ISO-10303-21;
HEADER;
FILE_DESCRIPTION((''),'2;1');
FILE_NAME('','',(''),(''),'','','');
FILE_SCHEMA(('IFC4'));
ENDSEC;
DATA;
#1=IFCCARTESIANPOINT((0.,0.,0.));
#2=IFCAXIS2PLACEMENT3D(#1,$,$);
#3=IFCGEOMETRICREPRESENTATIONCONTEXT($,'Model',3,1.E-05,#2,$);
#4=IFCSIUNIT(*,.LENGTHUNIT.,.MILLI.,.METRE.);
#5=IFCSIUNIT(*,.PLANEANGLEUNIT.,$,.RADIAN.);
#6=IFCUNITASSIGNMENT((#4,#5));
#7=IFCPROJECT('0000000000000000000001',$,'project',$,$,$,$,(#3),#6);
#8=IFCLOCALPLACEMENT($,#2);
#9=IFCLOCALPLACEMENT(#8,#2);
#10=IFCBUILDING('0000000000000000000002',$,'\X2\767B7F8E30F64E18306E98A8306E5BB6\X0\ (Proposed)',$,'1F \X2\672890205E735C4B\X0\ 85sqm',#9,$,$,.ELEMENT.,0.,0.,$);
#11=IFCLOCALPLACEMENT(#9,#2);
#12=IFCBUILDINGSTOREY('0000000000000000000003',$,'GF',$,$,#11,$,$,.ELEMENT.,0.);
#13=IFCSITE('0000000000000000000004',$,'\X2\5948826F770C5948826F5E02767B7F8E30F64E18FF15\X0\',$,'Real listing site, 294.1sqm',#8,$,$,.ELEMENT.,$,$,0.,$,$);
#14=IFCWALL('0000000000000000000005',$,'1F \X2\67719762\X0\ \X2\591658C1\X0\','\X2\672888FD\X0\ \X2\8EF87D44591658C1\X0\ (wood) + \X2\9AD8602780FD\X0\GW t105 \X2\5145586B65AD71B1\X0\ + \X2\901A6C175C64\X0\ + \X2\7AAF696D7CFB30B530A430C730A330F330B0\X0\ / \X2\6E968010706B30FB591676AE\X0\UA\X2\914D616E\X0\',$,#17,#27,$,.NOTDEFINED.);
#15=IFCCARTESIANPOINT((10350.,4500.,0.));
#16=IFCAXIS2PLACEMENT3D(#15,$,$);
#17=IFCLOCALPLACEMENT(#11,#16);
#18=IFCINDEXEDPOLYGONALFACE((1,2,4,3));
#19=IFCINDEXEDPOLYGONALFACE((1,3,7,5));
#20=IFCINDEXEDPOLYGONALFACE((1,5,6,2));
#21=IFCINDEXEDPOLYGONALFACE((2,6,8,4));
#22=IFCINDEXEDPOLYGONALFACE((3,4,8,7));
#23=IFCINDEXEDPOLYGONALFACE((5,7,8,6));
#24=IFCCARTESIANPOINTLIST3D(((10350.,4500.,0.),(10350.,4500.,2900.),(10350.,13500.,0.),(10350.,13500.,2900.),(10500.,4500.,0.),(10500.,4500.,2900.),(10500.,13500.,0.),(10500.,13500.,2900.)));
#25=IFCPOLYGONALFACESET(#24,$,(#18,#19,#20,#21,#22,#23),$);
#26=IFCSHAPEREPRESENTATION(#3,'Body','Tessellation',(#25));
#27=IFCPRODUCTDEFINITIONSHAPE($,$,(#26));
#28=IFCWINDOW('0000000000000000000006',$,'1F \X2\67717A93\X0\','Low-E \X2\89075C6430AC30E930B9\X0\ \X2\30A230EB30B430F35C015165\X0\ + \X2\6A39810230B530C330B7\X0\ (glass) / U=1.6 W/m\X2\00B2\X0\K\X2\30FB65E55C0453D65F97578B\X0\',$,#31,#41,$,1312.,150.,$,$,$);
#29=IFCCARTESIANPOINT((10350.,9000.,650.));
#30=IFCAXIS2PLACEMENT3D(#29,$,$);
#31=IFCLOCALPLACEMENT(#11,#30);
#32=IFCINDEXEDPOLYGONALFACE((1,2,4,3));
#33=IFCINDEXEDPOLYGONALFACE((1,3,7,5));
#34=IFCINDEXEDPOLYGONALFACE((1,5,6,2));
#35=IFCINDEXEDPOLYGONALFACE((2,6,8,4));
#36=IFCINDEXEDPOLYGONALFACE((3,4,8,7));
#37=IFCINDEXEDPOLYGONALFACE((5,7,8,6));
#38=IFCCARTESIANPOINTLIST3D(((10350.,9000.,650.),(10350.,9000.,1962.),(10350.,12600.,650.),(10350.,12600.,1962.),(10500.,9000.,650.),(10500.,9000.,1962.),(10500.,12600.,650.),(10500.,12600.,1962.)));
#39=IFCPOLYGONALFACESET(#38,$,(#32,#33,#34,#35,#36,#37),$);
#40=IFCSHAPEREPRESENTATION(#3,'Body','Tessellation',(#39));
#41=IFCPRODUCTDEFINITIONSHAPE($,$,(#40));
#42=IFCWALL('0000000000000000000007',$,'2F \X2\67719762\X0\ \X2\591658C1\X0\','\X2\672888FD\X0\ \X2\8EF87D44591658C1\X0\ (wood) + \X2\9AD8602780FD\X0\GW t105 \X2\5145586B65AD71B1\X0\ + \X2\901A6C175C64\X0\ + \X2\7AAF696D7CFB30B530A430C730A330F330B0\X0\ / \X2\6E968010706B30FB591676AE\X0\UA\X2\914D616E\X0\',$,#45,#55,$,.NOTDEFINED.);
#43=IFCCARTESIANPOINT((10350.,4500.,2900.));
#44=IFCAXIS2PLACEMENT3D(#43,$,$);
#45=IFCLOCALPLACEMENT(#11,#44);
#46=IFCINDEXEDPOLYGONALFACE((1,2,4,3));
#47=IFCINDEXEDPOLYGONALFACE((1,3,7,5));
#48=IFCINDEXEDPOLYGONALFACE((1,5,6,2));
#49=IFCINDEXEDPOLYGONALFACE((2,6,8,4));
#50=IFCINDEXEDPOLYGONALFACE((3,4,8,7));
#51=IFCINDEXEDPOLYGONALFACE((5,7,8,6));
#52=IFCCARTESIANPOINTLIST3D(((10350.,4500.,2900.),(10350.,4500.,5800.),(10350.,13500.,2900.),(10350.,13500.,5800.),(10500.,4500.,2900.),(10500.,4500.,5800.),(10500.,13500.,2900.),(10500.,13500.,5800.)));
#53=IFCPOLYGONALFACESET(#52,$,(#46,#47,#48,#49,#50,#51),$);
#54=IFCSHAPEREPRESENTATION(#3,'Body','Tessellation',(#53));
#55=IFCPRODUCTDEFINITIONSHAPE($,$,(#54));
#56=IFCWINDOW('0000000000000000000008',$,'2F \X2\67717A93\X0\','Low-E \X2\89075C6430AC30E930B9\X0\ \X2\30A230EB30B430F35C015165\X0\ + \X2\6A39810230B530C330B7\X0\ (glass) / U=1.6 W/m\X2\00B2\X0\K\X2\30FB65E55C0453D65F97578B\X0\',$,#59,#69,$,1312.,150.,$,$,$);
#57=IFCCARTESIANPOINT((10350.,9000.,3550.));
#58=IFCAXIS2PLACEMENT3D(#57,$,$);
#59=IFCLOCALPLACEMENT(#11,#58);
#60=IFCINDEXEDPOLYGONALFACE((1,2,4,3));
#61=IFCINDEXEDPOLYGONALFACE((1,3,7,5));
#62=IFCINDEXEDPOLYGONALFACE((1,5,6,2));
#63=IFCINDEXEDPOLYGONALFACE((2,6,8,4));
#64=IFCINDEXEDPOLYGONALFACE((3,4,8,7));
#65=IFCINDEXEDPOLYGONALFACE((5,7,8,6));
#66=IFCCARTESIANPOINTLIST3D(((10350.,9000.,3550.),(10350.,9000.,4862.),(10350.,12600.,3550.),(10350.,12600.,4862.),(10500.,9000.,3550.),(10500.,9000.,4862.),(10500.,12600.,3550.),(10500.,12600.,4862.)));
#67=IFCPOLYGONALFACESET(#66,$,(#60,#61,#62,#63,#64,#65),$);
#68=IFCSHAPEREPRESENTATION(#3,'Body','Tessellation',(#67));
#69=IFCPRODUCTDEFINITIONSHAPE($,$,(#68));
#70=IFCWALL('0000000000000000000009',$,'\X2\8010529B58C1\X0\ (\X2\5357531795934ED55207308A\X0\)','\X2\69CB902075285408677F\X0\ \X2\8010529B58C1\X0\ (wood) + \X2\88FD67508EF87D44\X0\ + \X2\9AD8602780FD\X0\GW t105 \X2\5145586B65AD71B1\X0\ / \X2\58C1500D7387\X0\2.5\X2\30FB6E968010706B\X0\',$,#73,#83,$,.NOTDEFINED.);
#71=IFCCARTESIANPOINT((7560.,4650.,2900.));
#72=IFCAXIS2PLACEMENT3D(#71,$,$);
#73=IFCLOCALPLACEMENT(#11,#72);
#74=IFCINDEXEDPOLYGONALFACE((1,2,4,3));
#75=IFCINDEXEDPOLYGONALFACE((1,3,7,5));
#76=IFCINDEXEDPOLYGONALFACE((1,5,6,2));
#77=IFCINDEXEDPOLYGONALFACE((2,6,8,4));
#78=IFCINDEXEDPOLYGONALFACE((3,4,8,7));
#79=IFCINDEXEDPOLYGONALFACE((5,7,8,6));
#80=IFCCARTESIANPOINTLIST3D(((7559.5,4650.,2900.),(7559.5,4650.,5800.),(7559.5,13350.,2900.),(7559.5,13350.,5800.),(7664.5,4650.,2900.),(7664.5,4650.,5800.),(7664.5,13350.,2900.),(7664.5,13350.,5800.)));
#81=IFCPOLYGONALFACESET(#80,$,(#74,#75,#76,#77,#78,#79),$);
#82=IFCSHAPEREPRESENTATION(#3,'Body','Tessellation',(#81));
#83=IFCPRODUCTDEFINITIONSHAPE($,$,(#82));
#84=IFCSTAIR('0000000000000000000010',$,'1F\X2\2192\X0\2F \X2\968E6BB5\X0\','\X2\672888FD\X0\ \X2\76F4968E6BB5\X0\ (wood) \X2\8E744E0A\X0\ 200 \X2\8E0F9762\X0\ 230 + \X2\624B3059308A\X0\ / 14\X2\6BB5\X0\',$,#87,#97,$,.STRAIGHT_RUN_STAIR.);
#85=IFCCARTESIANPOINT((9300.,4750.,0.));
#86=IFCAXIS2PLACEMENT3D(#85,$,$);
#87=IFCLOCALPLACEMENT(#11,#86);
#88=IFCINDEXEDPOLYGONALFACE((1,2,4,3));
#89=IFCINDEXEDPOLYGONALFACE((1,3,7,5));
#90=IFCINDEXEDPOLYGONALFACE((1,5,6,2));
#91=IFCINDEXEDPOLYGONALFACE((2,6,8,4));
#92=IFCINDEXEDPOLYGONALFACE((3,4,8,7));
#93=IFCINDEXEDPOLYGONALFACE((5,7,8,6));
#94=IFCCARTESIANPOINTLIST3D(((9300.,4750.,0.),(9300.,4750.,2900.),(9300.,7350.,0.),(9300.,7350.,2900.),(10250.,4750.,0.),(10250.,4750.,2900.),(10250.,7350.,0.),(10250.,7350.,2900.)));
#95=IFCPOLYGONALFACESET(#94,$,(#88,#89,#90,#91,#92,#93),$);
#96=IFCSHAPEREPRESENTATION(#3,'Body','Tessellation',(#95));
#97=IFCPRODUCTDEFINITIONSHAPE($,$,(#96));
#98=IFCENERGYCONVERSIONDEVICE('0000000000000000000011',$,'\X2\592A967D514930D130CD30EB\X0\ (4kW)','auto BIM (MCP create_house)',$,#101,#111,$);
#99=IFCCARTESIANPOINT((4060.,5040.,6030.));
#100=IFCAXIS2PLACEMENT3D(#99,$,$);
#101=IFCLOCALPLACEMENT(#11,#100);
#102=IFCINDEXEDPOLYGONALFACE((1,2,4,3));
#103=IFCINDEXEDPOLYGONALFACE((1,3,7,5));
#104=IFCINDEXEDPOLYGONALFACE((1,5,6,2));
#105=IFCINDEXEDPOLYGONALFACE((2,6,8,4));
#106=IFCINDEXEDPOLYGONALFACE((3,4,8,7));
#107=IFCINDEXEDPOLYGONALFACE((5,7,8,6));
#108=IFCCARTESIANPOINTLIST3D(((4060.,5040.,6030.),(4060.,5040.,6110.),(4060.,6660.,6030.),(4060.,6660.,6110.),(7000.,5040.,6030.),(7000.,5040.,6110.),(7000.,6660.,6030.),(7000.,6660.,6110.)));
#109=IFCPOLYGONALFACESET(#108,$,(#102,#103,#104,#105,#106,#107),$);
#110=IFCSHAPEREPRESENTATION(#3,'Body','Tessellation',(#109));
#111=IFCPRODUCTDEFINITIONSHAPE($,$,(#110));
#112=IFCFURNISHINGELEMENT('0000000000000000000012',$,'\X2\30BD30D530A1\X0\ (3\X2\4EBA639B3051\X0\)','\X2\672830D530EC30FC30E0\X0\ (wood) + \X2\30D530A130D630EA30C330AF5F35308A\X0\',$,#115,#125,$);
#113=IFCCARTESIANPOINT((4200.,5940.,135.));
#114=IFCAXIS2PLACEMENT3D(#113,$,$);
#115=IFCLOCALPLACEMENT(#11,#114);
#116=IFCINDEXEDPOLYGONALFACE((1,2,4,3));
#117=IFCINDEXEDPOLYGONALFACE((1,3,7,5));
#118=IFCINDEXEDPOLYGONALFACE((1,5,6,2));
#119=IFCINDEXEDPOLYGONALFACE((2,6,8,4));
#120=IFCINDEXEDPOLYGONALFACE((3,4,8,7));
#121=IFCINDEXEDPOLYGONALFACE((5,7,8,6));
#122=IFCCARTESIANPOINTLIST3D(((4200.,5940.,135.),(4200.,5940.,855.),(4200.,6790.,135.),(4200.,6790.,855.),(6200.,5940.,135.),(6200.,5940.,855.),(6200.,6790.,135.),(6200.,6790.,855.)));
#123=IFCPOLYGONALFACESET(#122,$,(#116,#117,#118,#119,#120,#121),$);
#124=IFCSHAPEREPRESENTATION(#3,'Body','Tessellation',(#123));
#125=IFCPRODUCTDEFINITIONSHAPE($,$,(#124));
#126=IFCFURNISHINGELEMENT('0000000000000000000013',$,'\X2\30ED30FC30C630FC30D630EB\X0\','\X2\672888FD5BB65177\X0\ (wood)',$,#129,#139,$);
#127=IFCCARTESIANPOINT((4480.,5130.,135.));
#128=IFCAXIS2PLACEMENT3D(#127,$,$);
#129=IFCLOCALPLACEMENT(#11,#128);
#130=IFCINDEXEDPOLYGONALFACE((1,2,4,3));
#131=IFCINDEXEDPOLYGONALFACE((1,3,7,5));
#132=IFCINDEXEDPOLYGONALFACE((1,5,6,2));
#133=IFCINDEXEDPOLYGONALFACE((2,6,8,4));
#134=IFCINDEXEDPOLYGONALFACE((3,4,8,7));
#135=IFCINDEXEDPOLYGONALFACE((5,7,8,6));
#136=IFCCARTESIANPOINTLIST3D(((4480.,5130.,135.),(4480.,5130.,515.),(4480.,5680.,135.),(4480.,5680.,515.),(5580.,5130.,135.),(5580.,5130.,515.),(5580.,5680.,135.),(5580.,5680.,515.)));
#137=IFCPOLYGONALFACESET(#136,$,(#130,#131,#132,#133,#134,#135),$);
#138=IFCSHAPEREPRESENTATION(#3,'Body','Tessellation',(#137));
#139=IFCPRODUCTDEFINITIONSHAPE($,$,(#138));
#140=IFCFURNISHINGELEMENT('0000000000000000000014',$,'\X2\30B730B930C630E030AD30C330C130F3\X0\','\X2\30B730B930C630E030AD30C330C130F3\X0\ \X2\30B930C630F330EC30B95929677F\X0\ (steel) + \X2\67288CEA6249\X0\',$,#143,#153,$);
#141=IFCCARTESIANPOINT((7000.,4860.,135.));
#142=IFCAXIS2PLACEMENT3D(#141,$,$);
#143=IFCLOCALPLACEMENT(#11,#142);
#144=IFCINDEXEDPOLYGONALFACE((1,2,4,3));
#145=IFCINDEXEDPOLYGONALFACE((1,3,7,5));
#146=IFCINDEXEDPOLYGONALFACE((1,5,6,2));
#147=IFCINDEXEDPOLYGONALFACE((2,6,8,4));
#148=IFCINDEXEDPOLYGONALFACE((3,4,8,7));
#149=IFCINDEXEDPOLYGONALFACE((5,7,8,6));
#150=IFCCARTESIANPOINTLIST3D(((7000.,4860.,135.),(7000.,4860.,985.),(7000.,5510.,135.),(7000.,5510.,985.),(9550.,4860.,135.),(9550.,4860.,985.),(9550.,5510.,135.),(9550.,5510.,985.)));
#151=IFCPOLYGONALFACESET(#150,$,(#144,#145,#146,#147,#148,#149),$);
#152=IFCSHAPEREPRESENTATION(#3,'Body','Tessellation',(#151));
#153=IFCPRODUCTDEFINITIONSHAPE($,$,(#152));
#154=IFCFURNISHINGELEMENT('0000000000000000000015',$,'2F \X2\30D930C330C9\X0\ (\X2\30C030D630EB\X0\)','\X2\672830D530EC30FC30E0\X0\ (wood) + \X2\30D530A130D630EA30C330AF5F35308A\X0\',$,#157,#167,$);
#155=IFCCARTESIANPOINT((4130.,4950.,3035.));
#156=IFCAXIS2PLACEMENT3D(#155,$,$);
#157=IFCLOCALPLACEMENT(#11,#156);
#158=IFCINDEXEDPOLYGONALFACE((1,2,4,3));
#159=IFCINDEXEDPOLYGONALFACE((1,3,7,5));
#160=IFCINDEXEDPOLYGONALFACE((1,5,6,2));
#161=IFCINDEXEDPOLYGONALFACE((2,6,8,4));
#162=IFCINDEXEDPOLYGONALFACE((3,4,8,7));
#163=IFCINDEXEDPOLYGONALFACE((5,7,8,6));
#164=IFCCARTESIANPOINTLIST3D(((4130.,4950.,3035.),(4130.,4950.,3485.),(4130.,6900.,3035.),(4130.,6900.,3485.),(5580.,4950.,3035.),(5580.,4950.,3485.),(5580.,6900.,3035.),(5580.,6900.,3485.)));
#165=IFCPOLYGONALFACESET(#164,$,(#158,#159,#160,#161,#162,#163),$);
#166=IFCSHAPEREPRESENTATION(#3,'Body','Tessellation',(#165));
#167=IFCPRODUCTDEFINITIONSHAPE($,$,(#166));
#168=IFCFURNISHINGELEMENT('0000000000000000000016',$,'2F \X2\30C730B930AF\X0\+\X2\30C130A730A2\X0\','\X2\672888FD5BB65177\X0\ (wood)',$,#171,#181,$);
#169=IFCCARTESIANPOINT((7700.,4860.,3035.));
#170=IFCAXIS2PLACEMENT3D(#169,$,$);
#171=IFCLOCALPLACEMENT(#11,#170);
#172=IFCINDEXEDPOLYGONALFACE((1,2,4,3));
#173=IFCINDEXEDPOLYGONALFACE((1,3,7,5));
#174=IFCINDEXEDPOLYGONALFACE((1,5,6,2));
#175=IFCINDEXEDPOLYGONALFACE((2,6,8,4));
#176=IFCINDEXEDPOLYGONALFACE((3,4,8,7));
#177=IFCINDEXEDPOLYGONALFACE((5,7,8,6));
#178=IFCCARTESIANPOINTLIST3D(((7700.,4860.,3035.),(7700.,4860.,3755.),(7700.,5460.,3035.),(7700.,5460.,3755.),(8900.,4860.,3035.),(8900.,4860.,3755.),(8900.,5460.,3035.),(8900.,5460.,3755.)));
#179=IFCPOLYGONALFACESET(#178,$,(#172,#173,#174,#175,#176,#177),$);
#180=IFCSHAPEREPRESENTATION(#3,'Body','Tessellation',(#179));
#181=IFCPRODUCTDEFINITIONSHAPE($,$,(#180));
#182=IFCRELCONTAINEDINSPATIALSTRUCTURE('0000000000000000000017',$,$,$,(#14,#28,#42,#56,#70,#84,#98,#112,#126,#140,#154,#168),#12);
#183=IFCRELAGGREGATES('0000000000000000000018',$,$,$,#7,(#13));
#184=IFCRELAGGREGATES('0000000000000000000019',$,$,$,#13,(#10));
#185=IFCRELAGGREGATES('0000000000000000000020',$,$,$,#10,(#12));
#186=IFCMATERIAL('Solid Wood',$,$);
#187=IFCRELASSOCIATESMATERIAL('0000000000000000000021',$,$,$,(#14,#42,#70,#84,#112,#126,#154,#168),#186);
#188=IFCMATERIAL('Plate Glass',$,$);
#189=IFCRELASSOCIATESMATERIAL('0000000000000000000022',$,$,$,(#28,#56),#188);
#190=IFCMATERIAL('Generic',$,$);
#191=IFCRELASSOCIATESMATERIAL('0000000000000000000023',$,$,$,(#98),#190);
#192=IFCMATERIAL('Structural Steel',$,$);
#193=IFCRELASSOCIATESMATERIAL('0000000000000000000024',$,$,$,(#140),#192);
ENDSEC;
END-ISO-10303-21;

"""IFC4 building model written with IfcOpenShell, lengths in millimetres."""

from ifc_helpers import new_model, si_unit, frame, frame_2d, origin, place, context, project, spatial, rectangle, extrude, material, element, fill, save


model = new_model("IFC4")

# Units and contexts
model_context = context("Model", 3, precision=1e-05, world=origin())
ifc_project = project(units=[si_unit("LENGTHUNIT", "METRE", prefix="MILLI"), si_unit("PLANEANGLEUNIT", "RADIAN")], contexts=[model_context])

# Site, building, storey
site_placement = place(None, origin())
site = spatial("IfcSite", under=ifc_project, at=site_placement, Name="奈良県奈良市登美ヶ丘５", ObjectType="Real listing site, 294.1sqm", CompositionType="ELEMENT", RefElevation=0.0)
building_placement = place(site_placement, origin())
building = spatial("IfcBuilding", under=site, at=building_placement, Name="登美ヶ丘の風の家 (Proposed)", ObjectType="1F 木造平屋 85sqm", CompositionType="ELEMENT", ElevationOfRefHeight=0.0, ElevationOfTerrain=0.0)
storey_placement = place(building_placement, origin())
storey = spatial("IfcBuildingStorey", under=building, at=storey_placement, Name="GF", CompositionType="ELEMENT", Elevation=0.0)

# Wall, opening, window
ifc_material_1 = material(Name="Solid Wood")
wall_1_placement = place(storey_placement, frame((10350.0, 4500.0, 0.0)))
wall_1 = element("IfcWall", 1, at=wall_1_placement, inside=storey, material=ifc_material_1, Name="1F 東面 外壁", Description="木製 軸組外壁 (wood) + 高性能GW t105 充填断熱 + 通気層 + 窯業系サイディング / 準耐火・外皮UA配慮", PredefinedType="NOTDEFINED", context=model_context, shape_type="SweptSolid", body=[
    extrude(rectangle(XDim=150.0, YDim=9000.0, at=frame_2d((75.0, 4500.0))), frame((10350.0, 4500.0, 0.0)), (0.0, 0.0, 1.0), 2900.0),
])
opening_1_placement = place(storey_placement, frame((10350.0, 9000.0, 650.0)))
opening_1 = element("IfcOpeningElement", 2, at=opening_1_placement, cuts=wall_1, PredefinedType="NOTDEFINED", context=model_context, shape_type="SweptSolid", body=[
    extrude(rectangle(XDim=150.0, YDim=3600.0, at=frame_2d((75.0, 1800.0))), frame((10350.0, 9000.0, 650.0)), (0.0, 0.0, 1.0), 1312.0),
])
ifc_material_2 = material(Name="Plate Glass")
window_1_placement = place(storey_placement, frame((10350.0, 9000.0, 650.0)))
window_1 = element("IfcWindow", 3, at=window_1_placement, inside=storey, material=ifc_material_2, Name="1F 東窓", Description="Low-E 複層ガラス アルゴン封入 + 樹脂サッシ (glass) / U=1.6 W/m²K・日射取得型", OverallHeight=1312.0, OverallWidth=150.0, context=model_context, shape_type="SweptSolid", body=[
    extrude(rectangle(XDim=150.0, YDim=3600.0, at=frame_2d((75.0, 1800.0))), frame((10350.0, 9000.0, 650.0)), (0.0, 0.0, 1.0), 1312.0),
])
fill(opening_1, window_1)

# Wall, opening, window
wall_2_placement = place(storey_placement, frame((10350.0, 4500.0, 2900.0)))
wall_2 = element("IfcWall", 4, at=wall_2_placement, inside=storey, material=ifc_material_1, Name="2F 東面 外壁", Description="木製 軸組外壁 (wood) + 高性能GW t105 充填断熱 + 通気層 + 窯業系サイディング / 準耐火・外皮UA配慮", PredefinedType="NOTDEFINED", context=model_context, shape_type="SweptSolid", body=[
    extrude(rectangle(XDim=150.0, YDim=9000.0, at=frame_2d((75.0, 4500.0))), frame((10350.0, 4500.0, 2900.0)), (0.0, 0.0, 1.0), 2900.0),
])
opening_2_placement = place(storey_placement, frame((10350.0, 9000.0, 3550.0)))
opening_2 = element("IfcOpeningElement", 5, at=opening_2_placement, cuts=wall_2, PredefinedType="NOTDEFINED", context=model_context, shape_type="SweptSolid", body=[
    extrude(rectangle(XDim=150.0, YDim=3600.0, at=frame_2d((75.0, 1800.0))), frame((10350.0, 9000.0, 3550.0)), (0.0, 0.0, 1.0), 1312.0),
])
window_2_placement = place(storey_placement, frame((10350.0, 9000.0, 3550.0)))
window_2 = element("IfcWindow", 6, at=window_2_placement, inside=storey, material=ifc_material_2, Name="2F 東窓", Description="Low-E 複層ガラス アルゴン封入 + 樹脂サッシ (glass) / U=1.6 W/m²K・日射取得型", OverallHeight=1312.0, OverallWidth=150.0, context=model_context, shape_type="SweptSolid", body=[
    extrude(rectangle(XDim=150.0, YDim=3600.0, at=frame_2d((75.0, 1800.0))), frame((10350.0, 9000.0, 3550.0)), (0.0, 0.0, 1.0), 1312.0),
])
fill(opening_2, window_2)

# Wall
wall_3_placement = place(storey_placement, frame((7560.0, 4650.0, 2900.0)))
element("IfcWall", 7, at=wall_3_placement, inside=storey, material=ifc_material_1, Name="耐力壁 (南北間仕切り)", Description="構造用合板 耐力壁 (wood) + 製材軸組 + 高性能GW t105 充填断熱 / 壁倍率2.5・準耐火", PredefinedType="NOTDEFINED", context=model_context, shape_type="SweptSolid", body=[
    extrude(rectangle(XDim=105.0, YDim=8700.0, at=frame_2d((52.0, 4350.0))), frame((7560.0, 4650.0, 2900.0)), (0.0, 0.0, 1.0), 2900.0),
])

# Stair
stair_placement = place(storey_placement, frame((9300.0, 4750.0, 0.0)))
element("IfcStair", 8, at=stair_placement, inside=storey, material=ifc_material_1, Name="1F→2F 階段", Description="木製 直階段 (wood) 蹴上 200 踏面 230 + 手すり / 14段", PredefinedType="STRAIGHT_RUN_STAIR", context=model_context, shape_type="SweptSolid", body=[
    extrude(rectangle(XDim=950.0, YDim=2600.0, at=frame_2d((475.0, 1300.0))), frame((9300.0, 4750.0, 0.0)), (0.0, 0.0, 1.0), 2900.0),
])

# Energy conversion device
ifc_material_3 = material(Name="Generic")
energy_conversion_device_placement = place(storey_placement, frame((4060.0, 5040.0, 6030.0)))
element("IfcEnergyConversionDevice", 9, at=energy_conversion_device_placement, inside=storey, material=ifc_material_3, Name="太陽光パネル (4kW)", Description="auto BIM (MCP create_house)", context=model_context, shape_type="SweptSolid", body=[
    extrude(rectangle(XDim=2940.0, YDim=1620.0, at=frame_2d((1470.0, 810.0))), frame((4060.0, 5040.0, 6030.0)), (0.0, 0.0, 1.0), 80.0),
])

# Furnishing elements
furnishing_1_placement = place(storey_placement, frame((4200.0, 5940.0, 135.0)))
element("IfcFurnishingElement", 10, at=furnishing_1_placement, inside=storey, material=ifc_material_1, Name="ソファ (3人掛け)", Description="木フレーム (wood) + ファブリック張り", context=model_context, shape_type="SweptSolid", body=[
    extrude(rectangle(XDim=2000.0, YDim=850.0, at=frame_2d((1000.0, 425.0))), frame((4200.0, 5940.0, 135.0)), (0.0, 0.0, 1.0), 720.0),
])
furnishing_2_placement = place(storey_placement, frame((4480.0, 5130.0, 135.0)))
element("IfcFurnishingElement", 11, at=furnishing_2_placement, inside=storey, material=ifc_material_1, Name="ローテーブル", Description="木製家具 (wood)", context=model_context, shape_type="SweptSolid", body=[
    extrude(rectangle(XDim=1100.0, YDim=550.0, at=frame_2d((550.0, 275.0))), frame((4480.0, 5130.0, 135.0)), (0.0, 0.0, 1.0), 380.0),
])
ifc_material_4 = material(Name="Structural Steel")
furnishing_3_placement = place(storey_placement, frame((7000.0, 4860.0, 135.0)))
element("IfcFurnishingElement", 12, at=furnishing_3_placement, inside=storey, material=ifc_material_4, Name="システムキッチン", Description="システムキッチン ステンレス天板 (steel) + 木質扉", context=model_context, shape_type="SweptSolid", body=[
    extrude(rectangle(XDim=2550.0, YDim=650.0, at=frame_2d((1275.0, 325.0))), frame((7000.0, 4860.0, 135.0)), (0.0, 0.0, 1.0), 850.0),
])
furnishing_4_placement = place(storey_placement, frame((4130.0, 4950.0, 3035.0)))
element("IfcFurnishingElement", 13, at=furnishing_4_placement, inside=storey, material=ifc_material_1, Name="2F ベッド (ダブル)", Description="木フレーム (wood) + ファブリック張り", context=model_context, shape_type="SweptSolid", body=[
    extrude(rectangle(XDim=1450.0, YDim=1950.0, at=frame_2d((725.0, 975.0))), frame((4130.0, 4950.0, 3035.0)), (0.0, 0.0, 1.0), 450.0),
])
furnishing_5_placement = place(storey_placement, frame((7700.0, 4860.0, 3035.0)))
element("IfcFurnishingElement", 14, at=furnishing_5_placement, inside=storey, material=ifc_material_1, Name="2F デスク+チェア", Description="木製家具 (wood)", context=model_context, shape_type="SweptSolid", body=[
    extrude(rectangle(XDim=1200.0, YDim=600.0, at=frame_2d((600.0, 300.0))), frame((7700.0, 4860.0, 3035.0)), (0.0, 0.0, 1.0), 720.0),
])

save(model, "model.ifc")
